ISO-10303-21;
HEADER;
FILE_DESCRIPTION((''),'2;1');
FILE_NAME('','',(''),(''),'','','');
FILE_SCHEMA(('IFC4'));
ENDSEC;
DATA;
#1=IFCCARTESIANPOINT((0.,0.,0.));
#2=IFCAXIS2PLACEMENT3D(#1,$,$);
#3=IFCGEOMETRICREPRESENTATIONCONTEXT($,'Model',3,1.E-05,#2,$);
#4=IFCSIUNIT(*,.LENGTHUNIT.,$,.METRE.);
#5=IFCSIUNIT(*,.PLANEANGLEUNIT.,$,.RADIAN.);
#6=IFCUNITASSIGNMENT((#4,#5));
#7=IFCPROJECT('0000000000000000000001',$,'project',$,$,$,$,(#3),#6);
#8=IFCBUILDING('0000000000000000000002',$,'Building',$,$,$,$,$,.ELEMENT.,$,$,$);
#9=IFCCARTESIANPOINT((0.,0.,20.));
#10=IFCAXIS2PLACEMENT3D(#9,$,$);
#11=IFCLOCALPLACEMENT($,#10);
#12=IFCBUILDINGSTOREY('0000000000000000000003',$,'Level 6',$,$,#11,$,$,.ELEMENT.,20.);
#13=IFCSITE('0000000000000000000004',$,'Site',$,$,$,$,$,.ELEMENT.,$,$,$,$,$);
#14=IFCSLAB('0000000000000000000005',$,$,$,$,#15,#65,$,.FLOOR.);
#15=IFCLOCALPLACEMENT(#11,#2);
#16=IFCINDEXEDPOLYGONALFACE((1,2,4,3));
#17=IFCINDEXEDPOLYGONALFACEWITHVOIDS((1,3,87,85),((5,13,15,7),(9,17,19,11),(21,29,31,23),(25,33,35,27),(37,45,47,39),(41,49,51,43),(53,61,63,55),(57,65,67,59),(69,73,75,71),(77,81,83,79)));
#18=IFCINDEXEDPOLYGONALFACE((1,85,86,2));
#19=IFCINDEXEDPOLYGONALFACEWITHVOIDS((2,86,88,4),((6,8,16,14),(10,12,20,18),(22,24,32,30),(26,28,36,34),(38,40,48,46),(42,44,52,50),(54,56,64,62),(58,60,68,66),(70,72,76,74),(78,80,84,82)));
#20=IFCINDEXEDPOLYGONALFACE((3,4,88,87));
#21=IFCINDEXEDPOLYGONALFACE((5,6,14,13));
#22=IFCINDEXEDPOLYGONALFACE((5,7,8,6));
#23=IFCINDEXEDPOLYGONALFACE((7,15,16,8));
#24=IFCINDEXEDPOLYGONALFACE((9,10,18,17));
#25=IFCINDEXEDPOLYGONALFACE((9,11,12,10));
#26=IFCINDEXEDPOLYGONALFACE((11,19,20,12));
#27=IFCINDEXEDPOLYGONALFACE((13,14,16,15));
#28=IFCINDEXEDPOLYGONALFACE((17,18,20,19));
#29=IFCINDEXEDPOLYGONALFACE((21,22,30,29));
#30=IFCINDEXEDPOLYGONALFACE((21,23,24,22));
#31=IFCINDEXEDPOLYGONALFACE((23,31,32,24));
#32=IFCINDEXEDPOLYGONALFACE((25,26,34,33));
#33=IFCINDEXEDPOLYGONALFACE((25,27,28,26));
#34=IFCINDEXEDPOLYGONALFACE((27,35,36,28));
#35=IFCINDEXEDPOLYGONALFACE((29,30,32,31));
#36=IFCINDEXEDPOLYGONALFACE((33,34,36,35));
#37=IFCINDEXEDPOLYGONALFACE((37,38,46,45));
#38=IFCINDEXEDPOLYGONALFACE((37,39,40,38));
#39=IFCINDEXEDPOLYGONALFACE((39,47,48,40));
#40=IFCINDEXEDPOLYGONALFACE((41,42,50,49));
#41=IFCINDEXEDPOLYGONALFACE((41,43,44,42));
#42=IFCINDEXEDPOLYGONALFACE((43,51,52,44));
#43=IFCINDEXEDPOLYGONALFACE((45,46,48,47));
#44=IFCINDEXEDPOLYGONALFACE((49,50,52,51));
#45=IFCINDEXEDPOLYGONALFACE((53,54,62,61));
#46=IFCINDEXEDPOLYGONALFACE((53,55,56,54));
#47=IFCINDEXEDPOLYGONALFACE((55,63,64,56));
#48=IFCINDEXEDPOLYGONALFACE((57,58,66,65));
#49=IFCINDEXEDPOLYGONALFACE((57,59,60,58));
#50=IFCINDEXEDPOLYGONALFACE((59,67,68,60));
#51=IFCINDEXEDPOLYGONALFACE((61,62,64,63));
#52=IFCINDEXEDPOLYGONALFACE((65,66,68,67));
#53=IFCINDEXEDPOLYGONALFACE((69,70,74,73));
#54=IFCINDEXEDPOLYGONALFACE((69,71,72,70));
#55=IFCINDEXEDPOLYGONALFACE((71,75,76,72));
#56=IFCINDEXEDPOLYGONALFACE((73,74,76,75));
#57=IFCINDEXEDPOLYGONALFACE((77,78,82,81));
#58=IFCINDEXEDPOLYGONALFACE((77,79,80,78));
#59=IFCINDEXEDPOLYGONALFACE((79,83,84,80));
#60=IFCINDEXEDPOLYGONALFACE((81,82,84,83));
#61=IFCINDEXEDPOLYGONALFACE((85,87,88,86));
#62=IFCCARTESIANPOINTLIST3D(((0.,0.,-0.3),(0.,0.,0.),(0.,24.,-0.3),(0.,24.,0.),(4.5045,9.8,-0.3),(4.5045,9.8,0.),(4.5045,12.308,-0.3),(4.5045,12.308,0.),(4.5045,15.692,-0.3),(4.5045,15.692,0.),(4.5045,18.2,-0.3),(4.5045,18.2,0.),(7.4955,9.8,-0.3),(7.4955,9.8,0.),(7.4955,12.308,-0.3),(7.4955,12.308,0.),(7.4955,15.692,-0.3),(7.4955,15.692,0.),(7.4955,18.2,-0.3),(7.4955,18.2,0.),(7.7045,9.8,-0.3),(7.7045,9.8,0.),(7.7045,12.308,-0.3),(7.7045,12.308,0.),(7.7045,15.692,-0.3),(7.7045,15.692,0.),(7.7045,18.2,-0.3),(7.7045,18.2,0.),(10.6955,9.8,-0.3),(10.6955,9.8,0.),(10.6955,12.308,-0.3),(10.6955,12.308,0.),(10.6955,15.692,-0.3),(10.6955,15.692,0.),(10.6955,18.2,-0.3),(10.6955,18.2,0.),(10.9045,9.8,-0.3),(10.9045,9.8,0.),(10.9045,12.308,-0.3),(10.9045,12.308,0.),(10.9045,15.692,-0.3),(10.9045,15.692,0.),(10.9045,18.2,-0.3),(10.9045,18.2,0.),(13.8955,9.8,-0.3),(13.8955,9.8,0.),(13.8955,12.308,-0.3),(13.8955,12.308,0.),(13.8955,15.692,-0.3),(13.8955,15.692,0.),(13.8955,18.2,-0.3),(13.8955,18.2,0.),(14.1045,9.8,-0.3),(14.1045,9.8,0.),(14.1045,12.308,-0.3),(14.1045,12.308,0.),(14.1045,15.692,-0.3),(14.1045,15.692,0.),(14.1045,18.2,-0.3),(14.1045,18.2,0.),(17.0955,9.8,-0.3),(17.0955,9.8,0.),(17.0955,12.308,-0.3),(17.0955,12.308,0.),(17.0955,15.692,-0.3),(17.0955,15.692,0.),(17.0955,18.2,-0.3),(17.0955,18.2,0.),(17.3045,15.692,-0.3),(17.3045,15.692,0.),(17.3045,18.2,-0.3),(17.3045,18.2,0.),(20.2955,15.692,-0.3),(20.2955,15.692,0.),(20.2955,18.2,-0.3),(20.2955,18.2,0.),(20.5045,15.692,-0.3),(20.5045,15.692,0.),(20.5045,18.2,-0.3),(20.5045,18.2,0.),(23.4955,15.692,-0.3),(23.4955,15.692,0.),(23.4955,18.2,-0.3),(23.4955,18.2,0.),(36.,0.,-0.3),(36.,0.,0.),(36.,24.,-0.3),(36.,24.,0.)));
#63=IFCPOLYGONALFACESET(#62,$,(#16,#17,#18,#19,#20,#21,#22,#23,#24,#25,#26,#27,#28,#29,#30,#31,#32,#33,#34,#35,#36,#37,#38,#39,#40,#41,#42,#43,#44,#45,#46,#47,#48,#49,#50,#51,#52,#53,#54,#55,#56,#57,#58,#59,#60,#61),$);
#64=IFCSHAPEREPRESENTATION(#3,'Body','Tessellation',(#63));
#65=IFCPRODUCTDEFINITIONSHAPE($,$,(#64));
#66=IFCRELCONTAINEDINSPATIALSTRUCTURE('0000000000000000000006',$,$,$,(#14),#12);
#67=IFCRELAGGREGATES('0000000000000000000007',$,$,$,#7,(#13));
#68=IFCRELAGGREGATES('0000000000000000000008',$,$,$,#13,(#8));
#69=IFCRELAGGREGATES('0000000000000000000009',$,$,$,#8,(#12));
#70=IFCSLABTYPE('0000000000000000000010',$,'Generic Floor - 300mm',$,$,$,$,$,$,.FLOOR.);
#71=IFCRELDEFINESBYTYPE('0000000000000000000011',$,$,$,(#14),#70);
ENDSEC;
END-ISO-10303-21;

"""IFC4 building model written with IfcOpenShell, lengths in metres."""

from ifc_helpers import new_model, si_unit, frame, origin, place, context, project, spatial, polyline, outline, extrude, type_object, element, save


model = new_model("IFC4")

# Units and contexts
model_context = context("Model", 3, precision=1e-05, world=origin())
ifc_project = project(units=[si_unit("LENGTHUNIT", "METRE"), si_unit("PLANEANGLEUNIT", "RADIAN")], contexts=[model_context])

# Site, building, storey
site = spatial("IfcSite", under=ifc_project, Name="Site", CompositionType="ELEMENT")
building = spatial("IfcBuilding", under=site, Name="Building", CompositionType="ELEMENT")
storey_placement = place(None, frame((0.0, 0.0, 20.0)))
storey = spatial("IfcBuildingStorey", under=building, at=storey_placement, Name="Level 6", CompositionType="ELEMENT", Elevation=20.0)

# Slab, openings
slab_type = type_object("IfcSlabType", Name="Generic Floor - 300mm", PredefinedType="FLOOR")
slab_placement = place(None, frame((0.0, 0.0, 20.0)))
slab = element("IfcSlab", 1, at=slab_placement, inside=storey, type_object=slab_type, PredefinedType="FLOOR", context=model_context, shape_type="SweptSolid", body=[
    extrude(outline(polyline([(0.0, 0.0), (36.0, 0.0), (36.0, 24.0), (0.0, 24.0), (0.0, 0.0)])), origin(), (0.0, 0.0, -1.0), 0.3),
])
opening_1_placement = place(None, frame((0.0, 0.0, 20.001)))
element("IfcOpeningElement", 2, at=opening_1_placement, cuts=slab, PredefinedType="OPENING", context=model_context, shape_type="SweptSolid", body=[
    extrude(outline(polyline([(4.5045, 9.8), (7.4955, 9.8), (7.4955, 12.308), (4.5045, 12.308), (4.5045, 9.8)])), origin(), (0.0, 0.0, -1.0), 0.302),
])
opening_2_placement = place(None, frame((0.0, 0.0, 20.001)))
element("IfcOpeningElement", 3, at=opening_2_placement, cuts=slab, PredefinedType="OPENING", context=model_context, shape_type="SweptSolid", body=[
    extrude(outline(polyline([(7.7045, 9.8), (10.6955, 9.8), (10.6955, 12.308), (7.7045, 12.308), (7.7045, 9.8)])), origin(), (0.0, 0.0, -1.0), 0.302),
])
opening_3_placement = place(None, frame((0.0, 0.0, 20.001)))
element("IfcOpeningElement", 4, at=opening_3_placement, cuts=slab, PredefinedType="OPENING", context=model_context, shape_type="SweptSolid", body=[
    extrude(outline(polyline([(10.9045, 9.8), (13.8955, 9.8), (13.8955, 12.308), (10.9045, 12.308), (10.9045, 9.8)])), origin(), (0.0, 0.0, -1.0), 0.302),
])
opening_4_placement = place(None, frame((0.0, 0.0, 20.001)))
element("IfcOpeningElement", 5, at=opening_4_placement, cuts=slab, PredefinedType="OPENING", context=model_context, shape_type="SweptSolid", body=[
    extrude(outline(polyline([(14.1045, 9.8), (17.0955, 9.8), (17.0955, 12.308), (14.1045, 12.308), (14.1045, 9.8)])), origin(), (0.0, 0.0, -1.0), 0.302),
])
opening_5_placement = place(None, frame((0.0, 0.0, 20.001)))
element("IfcOpeningElement", 6, at=opening_5_placement, cuts=slab, PredefinedType="OPENING", context=model_context, shape_type="SweptSolid", body=[
    extrude(outline(polyline([(7.4955, 18.2), (4.5045, 18.2), (4.5045, 15.692), (7.4955, 15.692), (7.4955, 18.2)])), origin(), (0.0, 0.0, -1.0), 0.302),
])
opening_6_placement = place(None, frame((0.0, 0.0, 20.001)))
element("IfcOpeningElement", 7, at=opening_6_placement, cuts=slab, PredefinedType="OPENING", context=model_context, shape_type="SweptSolid", body=[
    extrude(outline(polyline([(10.6955, 18.2), (7.7045, 18.2), (7.7045, 15.692), (10.6955, 15.692), (10.6955, 18.2)])), origin(), (0.0, 0.0, -1.0), 0.302),
])
opening_7_placement = place(None, frame((0.0, 0.0, 20.001)))
element("IfcOpeningElement", 8, at=opening_7_placement, cuts=slab, PredefinedType="OPENING", context=model_context, shape_type="SweptSolid", body=[
    extrude(outline(polyline([(13.8955, 18.2), (10.9045, 18.2), (10.9045, 15.692), (13.8955, 15.692), (13.8955, 18.2)])), origin(), (0.0, 0.0, -1.0), 0.302),
])
opening_8_placement = place(None, frame((0.0, 0.0, 20.001)))
element("IfcOpeningElement", 9, at=opening_8_placement, cuts=slab, PredefinedType="OPENING", context=model_context, shape_type="SweptSolid", body=[
    extrude(outline(polyline([(17.0955, 18.2), (14.1045, 18.2), (14.1045, 15.692), (17.0955, 15.692), (17.0955, 18.2)])), origin(), (0.0, 0.0, -1.0), 0.302),
])
opening_9_placement = place(None, frame((0.0, 0.0, 20.001)))
element("IfcOpeningElement", 10, at=opening_9_placement, cuts=slab, PredefinedType="OPENING", context=model_context, shape_type="SweptSolid", body=[
    extrude(outline(polyline([(20.2955, 18.2), (17.3045, 18.2), (17.3045, 15.692), (20.2955, 15.692), (20.2955, 18.2)])), origin(), (0.0, 0.0, -1.0), 0.302),
])
opening_10_placement = place(None, frame((0.0, 0.0, 20.001)))
element("IfcOpeningElement", 11, at=opening_10_placement, cuts=slab, PredefinedType="OPENING", context=model_context, shape_type="SweptSolid", body=[
    extrude(outline(polyline([(23.4955, 18.2), (20.5045, 18.2), (20.5045, 15.692), (23.4955, 15.692), (23.4955, 18.2)])), origin(), (0.0, 0.0, -1.0), 0.302),
])

save(model, "model.ifc")
